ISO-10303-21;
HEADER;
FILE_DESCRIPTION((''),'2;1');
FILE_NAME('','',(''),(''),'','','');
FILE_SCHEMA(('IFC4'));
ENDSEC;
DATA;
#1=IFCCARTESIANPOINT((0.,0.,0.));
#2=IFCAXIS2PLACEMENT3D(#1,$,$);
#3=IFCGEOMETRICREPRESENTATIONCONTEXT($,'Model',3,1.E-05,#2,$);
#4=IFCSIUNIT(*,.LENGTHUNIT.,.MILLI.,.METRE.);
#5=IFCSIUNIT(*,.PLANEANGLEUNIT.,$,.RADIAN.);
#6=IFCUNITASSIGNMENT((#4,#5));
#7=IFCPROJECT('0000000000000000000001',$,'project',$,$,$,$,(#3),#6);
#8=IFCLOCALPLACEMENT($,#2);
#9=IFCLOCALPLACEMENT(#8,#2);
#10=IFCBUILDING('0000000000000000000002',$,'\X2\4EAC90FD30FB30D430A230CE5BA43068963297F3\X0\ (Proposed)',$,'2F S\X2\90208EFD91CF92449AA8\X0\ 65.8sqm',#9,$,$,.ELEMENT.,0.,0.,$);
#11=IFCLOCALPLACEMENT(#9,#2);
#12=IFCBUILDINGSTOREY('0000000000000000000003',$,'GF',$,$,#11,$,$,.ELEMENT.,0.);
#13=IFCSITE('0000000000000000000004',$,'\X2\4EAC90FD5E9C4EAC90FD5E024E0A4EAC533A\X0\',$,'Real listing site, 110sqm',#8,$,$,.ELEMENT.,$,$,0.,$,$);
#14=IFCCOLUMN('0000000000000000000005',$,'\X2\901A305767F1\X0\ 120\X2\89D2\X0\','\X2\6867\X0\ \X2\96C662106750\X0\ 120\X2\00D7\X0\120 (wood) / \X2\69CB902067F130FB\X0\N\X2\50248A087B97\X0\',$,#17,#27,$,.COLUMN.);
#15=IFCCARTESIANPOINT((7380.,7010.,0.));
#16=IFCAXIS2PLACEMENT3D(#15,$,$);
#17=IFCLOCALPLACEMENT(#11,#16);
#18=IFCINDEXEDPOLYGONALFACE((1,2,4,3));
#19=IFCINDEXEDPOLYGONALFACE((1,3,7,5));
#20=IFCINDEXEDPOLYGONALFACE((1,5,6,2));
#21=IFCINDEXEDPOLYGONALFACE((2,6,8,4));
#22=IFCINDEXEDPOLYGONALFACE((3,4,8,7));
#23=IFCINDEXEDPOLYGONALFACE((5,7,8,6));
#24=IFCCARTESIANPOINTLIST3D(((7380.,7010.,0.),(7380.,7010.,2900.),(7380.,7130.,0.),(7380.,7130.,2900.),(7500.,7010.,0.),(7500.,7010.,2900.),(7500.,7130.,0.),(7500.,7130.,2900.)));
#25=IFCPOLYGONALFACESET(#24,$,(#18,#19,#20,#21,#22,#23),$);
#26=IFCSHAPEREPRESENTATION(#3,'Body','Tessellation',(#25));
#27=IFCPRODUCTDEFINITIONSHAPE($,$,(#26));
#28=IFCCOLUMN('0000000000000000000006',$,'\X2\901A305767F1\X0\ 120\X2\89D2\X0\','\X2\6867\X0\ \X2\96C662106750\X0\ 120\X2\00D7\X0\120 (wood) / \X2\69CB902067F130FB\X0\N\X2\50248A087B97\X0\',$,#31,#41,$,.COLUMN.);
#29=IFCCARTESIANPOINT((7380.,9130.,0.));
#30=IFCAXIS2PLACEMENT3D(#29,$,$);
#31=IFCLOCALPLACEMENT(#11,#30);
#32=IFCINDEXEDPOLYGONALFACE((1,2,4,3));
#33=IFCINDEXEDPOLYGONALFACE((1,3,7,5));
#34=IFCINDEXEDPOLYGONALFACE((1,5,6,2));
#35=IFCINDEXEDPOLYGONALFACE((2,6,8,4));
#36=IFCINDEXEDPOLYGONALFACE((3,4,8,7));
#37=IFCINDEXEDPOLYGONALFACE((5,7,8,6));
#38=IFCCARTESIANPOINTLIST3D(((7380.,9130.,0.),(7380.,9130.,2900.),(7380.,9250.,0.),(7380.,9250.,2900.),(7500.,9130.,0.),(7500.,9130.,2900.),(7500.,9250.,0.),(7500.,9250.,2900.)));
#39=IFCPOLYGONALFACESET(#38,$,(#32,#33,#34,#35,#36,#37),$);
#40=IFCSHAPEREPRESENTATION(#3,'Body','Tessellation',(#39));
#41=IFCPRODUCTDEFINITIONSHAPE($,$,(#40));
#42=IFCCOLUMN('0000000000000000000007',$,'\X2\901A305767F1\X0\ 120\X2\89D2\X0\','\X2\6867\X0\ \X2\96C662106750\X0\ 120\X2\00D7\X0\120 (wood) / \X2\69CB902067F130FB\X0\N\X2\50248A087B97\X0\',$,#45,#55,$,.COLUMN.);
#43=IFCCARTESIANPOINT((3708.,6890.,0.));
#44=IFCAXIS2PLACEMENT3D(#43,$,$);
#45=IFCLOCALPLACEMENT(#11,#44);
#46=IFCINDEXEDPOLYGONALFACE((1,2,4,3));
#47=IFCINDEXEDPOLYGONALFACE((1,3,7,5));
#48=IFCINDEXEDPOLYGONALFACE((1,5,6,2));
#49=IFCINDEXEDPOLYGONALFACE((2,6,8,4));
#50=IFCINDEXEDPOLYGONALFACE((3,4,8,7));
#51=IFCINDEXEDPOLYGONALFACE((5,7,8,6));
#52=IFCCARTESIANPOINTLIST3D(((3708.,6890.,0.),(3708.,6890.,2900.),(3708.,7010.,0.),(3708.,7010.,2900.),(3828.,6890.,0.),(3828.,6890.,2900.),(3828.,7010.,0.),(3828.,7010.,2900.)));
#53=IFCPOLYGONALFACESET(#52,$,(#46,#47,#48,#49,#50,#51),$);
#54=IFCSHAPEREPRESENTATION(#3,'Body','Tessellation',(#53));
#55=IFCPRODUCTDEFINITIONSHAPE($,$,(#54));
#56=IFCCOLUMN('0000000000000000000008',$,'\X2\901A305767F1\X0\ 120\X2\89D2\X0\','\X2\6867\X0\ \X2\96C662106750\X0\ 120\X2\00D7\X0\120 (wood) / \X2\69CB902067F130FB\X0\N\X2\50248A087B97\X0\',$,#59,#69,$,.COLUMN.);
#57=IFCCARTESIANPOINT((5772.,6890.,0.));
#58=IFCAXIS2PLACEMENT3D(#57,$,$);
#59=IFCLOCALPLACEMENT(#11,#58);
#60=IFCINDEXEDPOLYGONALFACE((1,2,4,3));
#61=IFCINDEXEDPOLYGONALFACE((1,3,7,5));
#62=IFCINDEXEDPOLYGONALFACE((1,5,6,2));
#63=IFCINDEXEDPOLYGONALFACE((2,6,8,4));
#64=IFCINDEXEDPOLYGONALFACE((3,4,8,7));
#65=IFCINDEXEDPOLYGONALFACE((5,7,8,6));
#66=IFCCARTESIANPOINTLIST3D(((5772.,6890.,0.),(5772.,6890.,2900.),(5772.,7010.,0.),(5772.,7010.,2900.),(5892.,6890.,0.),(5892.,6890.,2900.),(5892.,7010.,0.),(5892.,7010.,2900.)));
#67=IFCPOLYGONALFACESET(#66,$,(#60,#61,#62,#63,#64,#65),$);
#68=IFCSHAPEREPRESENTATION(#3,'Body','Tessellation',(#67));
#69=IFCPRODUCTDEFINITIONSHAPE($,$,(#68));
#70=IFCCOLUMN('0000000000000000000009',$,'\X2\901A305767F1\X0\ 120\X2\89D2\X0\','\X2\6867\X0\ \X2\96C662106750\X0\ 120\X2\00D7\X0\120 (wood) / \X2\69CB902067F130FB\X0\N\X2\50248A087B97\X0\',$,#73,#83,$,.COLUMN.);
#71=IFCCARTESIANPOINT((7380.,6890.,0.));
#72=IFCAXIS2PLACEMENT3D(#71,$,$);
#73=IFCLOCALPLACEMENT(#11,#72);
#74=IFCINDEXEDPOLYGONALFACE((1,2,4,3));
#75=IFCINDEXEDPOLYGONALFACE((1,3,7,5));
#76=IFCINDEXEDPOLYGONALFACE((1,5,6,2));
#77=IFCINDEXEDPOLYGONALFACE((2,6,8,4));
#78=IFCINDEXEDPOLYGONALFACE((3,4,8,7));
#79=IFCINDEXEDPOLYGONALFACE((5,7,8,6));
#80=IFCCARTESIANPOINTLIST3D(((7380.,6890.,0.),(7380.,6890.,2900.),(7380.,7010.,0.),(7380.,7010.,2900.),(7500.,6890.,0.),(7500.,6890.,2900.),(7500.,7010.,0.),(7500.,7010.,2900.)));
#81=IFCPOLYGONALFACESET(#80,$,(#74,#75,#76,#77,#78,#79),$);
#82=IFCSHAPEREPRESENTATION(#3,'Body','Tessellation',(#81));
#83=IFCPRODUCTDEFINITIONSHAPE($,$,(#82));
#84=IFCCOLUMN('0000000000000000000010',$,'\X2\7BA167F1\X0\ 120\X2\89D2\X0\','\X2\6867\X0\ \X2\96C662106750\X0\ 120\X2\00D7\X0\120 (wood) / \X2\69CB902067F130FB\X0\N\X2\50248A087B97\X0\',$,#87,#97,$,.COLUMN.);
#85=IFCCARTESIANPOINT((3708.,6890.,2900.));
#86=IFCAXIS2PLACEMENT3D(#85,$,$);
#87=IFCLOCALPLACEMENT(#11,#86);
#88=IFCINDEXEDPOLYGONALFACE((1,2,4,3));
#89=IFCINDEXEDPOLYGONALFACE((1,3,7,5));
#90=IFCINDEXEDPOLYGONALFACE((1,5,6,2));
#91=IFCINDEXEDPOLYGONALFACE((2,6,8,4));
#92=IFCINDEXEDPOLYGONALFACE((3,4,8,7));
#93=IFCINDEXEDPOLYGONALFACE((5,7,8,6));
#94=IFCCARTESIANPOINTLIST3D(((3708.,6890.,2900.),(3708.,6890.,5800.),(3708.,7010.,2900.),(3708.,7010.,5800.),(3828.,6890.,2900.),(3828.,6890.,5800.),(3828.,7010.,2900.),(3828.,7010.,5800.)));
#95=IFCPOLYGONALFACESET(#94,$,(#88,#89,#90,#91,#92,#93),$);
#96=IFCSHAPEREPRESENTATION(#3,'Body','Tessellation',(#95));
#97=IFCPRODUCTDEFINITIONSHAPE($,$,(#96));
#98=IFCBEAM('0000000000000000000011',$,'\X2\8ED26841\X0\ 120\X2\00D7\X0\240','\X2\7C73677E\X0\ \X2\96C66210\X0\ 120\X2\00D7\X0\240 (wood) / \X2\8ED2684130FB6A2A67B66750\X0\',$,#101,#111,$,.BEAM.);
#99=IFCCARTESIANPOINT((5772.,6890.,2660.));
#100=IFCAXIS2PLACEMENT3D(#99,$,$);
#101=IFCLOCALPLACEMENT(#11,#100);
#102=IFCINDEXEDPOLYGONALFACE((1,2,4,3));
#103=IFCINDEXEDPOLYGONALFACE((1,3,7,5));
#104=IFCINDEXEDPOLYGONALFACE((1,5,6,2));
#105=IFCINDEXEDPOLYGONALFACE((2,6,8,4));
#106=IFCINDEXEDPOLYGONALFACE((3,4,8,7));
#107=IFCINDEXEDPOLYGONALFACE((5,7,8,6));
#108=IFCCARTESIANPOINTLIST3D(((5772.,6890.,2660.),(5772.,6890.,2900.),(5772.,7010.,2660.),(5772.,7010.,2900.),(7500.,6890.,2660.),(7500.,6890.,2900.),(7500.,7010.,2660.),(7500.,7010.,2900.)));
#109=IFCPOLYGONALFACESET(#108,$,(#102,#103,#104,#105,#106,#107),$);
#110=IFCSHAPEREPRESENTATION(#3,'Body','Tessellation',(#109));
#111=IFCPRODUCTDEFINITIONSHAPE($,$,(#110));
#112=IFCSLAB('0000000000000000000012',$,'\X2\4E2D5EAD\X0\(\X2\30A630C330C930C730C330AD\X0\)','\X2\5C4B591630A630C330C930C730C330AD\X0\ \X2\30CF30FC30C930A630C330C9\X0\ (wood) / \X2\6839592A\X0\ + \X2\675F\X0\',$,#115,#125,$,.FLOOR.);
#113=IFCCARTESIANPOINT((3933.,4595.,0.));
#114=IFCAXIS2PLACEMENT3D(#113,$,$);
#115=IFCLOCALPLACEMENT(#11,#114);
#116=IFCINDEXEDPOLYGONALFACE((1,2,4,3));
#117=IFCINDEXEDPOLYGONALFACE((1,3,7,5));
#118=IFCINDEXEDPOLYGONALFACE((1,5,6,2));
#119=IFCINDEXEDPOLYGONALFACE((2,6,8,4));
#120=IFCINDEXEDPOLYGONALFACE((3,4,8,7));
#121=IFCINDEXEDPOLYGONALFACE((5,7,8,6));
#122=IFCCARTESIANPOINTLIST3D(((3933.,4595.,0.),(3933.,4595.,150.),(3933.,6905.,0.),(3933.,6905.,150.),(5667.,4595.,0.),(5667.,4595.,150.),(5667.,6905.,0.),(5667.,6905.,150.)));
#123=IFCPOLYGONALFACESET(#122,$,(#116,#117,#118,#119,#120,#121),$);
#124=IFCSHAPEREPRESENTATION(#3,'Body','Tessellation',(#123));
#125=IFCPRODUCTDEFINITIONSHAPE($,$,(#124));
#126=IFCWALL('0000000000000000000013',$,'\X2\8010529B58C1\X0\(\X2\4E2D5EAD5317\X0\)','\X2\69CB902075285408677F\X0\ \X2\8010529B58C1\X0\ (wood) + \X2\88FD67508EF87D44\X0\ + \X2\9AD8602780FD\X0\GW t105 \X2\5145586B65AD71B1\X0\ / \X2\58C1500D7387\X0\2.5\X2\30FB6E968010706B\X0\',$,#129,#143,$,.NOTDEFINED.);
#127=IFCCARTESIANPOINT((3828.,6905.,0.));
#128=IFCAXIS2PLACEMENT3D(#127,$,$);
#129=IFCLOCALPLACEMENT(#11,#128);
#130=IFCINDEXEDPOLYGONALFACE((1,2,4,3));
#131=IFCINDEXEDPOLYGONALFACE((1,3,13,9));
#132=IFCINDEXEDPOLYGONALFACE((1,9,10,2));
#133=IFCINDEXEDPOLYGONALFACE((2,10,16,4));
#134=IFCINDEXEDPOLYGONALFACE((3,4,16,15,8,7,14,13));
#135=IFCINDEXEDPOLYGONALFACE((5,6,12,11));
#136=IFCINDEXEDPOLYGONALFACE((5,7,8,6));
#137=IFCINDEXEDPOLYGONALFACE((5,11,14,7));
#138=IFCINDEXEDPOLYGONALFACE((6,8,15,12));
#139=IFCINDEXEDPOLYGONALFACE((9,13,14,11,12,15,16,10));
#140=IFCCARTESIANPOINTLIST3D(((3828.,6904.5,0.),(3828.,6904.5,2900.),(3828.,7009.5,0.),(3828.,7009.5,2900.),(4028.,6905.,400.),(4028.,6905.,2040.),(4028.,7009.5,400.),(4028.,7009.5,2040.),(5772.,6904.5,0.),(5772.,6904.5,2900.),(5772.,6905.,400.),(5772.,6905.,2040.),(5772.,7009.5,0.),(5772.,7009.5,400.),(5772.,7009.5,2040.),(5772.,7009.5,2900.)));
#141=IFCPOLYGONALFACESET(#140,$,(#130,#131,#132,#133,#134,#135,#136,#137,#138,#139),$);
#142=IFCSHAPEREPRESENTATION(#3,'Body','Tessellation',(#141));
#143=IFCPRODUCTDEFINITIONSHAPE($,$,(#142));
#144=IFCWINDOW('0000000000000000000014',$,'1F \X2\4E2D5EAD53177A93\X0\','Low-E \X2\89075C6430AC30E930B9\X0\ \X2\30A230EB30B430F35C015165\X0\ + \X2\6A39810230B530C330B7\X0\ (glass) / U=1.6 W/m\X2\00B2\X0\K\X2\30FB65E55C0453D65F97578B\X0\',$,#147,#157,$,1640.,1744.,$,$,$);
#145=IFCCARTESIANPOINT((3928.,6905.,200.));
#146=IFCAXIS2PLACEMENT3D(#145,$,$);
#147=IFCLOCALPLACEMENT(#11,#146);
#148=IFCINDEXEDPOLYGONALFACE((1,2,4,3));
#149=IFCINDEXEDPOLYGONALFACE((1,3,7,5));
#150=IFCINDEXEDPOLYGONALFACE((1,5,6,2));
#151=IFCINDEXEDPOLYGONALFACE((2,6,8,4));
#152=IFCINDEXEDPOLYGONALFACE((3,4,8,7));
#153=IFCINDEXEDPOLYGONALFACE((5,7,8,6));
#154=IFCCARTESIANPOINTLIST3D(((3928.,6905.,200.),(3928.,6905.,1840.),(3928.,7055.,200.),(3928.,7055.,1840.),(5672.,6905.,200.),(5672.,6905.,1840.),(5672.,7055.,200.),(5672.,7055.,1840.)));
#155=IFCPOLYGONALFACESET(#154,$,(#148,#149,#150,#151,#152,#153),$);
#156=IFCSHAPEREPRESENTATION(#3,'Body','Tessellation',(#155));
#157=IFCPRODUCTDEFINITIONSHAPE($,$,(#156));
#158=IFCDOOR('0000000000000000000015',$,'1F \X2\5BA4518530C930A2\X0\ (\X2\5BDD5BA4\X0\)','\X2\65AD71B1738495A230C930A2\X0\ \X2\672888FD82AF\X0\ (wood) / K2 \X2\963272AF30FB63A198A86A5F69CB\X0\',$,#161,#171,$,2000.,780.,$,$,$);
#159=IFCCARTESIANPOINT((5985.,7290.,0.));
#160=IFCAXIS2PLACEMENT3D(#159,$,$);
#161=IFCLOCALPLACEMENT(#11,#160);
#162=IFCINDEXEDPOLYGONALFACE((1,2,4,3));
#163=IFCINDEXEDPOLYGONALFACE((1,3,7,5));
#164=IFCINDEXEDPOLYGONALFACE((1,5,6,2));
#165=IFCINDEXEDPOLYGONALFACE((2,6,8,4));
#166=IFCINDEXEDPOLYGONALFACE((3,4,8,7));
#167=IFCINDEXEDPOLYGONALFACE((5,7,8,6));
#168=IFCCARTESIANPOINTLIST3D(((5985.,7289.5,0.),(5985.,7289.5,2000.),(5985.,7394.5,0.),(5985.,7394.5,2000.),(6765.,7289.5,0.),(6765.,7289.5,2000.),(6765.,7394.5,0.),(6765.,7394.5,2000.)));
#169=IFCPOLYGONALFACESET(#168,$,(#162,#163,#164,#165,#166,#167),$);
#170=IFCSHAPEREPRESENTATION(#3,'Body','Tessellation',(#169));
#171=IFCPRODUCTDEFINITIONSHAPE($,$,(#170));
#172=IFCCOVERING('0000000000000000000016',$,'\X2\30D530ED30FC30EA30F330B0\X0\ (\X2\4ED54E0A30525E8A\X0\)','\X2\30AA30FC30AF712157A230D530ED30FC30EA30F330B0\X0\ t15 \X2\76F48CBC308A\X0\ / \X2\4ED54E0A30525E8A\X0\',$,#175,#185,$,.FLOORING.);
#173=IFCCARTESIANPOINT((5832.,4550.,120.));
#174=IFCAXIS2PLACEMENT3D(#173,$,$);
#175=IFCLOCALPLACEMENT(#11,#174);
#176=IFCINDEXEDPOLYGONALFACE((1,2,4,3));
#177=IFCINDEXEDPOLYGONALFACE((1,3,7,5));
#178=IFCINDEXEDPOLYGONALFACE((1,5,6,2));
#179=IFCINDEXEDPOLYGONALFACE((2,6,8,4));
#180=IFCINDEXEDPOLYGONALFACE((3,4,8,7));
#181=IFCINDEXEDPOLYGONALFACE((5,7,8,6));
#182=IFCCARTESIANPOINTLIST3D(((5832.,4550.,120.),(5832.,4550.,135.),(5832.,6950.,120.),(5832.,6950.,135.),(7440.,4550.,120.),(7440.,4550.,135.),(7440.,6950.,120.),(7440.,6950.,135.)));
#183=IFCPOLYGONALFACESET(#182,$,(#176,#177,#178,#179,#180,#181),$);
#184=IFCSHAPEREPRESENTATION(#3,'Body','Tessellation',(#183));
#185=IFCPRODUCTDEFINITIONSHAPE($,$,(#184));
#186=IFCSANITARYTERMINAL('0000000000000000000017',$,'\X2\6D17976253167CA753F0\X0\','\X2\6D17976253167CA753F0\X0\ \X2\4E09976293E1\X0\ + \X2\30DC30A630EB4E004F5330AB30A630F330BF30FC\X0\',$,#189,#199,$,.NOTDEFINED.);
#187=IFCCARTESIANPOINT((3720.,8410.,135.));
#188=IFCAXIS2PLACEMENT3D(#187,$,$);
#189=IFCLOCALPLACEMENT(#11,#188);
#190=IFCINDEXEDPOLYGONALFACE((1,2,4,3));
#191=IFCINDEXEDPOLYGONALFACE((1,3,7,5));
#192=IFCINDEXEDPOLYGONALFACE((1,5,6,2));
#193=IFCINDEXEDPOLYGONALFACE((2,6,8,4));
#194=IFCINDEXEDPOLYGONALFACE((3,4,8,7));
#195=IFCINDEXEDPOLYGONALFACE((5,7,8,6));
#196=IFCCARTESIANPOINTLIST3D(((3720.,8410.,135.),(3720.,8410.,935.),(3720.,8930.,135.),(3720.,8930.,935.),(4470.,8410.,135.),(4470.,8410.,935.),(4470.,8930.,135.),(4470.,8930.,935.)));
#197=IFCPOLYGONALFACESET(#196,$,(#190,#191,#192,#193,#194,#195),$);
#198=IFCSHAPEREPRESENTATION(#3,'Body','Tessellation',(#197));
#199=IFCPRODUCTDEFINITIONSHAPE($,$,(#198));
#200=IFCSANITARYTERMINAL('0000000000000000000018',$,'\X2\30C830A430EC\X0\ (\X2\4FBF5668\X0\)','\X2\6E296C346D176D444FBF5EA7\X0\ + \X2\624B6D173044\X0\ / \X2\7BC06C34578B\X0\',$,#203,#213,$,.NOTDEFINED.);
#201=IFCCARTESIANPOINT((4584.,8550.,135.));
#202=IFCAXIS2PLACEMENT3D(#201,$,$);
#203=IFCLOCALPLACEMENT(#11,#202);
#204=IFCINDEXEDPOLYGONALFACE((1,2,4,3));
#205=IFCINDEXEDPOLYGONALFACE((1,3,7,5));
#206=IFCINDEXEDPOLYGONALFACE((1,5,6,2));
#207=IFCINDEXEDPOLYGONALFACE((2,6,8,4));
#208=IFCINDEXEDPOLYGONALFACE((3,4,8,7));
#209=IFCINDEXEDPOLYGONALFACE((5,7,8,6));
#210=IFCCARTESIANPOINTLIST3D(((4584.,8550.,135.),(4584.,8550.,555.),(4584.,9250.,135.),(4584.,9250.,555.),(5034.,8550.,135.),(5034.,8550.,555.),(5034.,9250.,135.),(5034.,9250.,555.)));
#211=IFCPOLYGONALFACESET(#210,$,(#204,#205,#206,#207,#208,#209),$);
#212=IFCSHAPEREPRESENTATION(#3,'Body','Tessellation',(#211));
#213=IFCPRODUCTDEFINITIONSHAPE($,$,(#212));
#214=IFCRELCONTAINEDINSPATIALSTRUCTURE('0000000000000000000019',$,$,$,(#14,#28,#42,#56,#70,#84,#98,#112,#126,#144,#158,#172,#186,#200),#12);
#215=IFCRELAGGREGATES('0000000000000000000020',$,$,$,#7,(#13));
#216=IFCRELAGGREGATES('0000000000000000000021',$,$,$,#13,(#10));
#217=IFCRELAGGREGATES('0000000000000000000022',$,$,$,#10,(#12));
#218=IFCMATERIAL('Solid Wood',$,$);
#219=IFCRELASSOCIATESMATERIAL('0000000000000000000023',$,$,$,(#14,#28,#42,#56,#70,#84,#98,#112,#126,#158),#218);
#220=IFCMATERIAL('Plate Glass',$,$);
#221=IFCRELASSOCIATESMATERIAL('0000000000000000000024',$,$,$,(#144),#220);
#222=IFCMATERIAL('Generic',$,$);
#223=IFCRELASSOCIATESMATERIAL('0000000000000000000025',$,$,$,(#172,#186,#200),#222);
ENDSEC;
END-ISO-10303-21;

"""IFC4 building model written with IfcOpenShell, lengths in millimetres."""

from ifc_helpers import new_model, si_unit, frame, frame_2d, origin, place, context, project, spatial, rectangle, extrude, material, element, fill, save


model = new_model("IFC4")

# Units and contexts
model_context = context("Model", 3, precision=1e-05, world=origin())
ifc_project = project(units=[si_unit("LENGTHUNIT", "METRE", prefix="MILLI"), si_unit("PLANEANGLEUNIT", "RADIAN")], contexts=[model_context])

# Site, building, storey
site_placement = place(None, origin())
site = spatial("IfcSite", under=ifc_project, at=site_placement, Name="京都府京都市上京区", ObjectType="Real listing site, 110sqm", CompositionType="ELEMENT", RefElevation=0.0)
building_placement = place(site_placement, origin())
building = spatial("IfcBuilding", under=site, at=building_placement, Name="京都・ピアノ室と防音 (Proposed)", ObjectType="2F S造軽量鉄骨 65.8sqm", CompositionType="ELEMENT", ElevationOfRefHeight=0.0, ElevationOfTerrain=0.0)
storey_placement = place(building_placement, origin())
storey = spatial("IfcBuildingStorey", under=building, at=storey_placement, Name="GF", CompositionType="ELEMENT", Elevation=0.0)

# Columns
ifc_material_1 = material(Name="Solid Wood")
column_1_placement = place(storey_placement, frame((7380.0, 7010.0, 0.0)))
element("IfcColumn", 1, at=column_1_placement, inside=storey, material=ifc_material_1, Name="通し柱 120角", Description="桧 集成材 120×120 (wood) / 構造柱・N値計算", PredefinedType="COLUMN", context=model_context, shape_type="SweptSolid", body=[
    extrude(rectangle(XDim=120.0, YDim=120.0, at=frame_2d((60.0, 60.0))), frame((7380.0, 7010.0, 0.0)), (0.0, 0.0, 1.0), 2900.0),
])
column_2_placement = place(storey_placement, frame((7380.0, 9130.0, 0.0)))
element("IfcColumn", 2, at=column_2_placement, inside=storey, material=ifc_material_1, Name="通し柱 120角", Description="桧 集成材 120×120 (wood) / 構造柱・N値計算", PredefinedType="COLUMN", context=model_context, shape_type="SweptSolid", body=[
    extrude(rectangle(XDim=120.0, YDim=120.0, at=frame_2d((60.0, 60.0))), frame((7380.0, 9130.0, 0.0)), (0.0, 0.0, 1.0), 2900.0),
])
column_3_placement = place(storey_placement, frame((3708.0, 6890.0, 0.0)))
element("IfcColumn", 3, at=column_3_placement, inside=storey, material=ifc_material_1, Name="通し柱 120角", Description="桧 集成材 120×120 (wood) / 構造柱・N値計算", PredefinedType="COLUMN", context=model_context, shape_type="SweptSolid", body=[
    extrude(rectangle(XDim=120.0, YDim=120.0, at=frame_2d((60.0, 60.0))), frame((3708.0, 6890.0, 0.0)), (0.0, 0.0, 1.0), 2900.0),
])
column_4_placement = place(storey_placement, frame((5772.0, 6890.0, 0.0)))
element("IfcColumn", 4, at=column_4_placement, inside=storey, material=ifc_material_1, Name="通し柱 120角", Description="桧 集成材 120×120 (wood) / 構造柱・N値計算", PredefinedType="COLUMN", context=model_context, shape_type="SweptSolid", body=[
    extrude(rectangle(XDim=120.0, YDim=120.0, at=frame_2d((60.0, 60.0))), frame((5772.0, 6890.0, 0.0)), (0.0, 0.0, 1.0), 2900.0),
])
column_5_placement = place(storey_placement, frame((7380.0, 6890.0, 0.0)))
element("IfcColumn", 5, at=column_5_placement, inside=storey, material=ifc_material_1, Name="通し柱 120角", Description="桧 集成材 120×120 (wood) / 構造柱・N値計算", PredefinedType="COLUMN", context=model_context, shape_type="SweptSolid", body=[
    extrude(rectangle(XDim=120.0, YDim=120.0, at=frame_2d((60.0, 60.0))), frame((7380.0, 6890.0, 0.0)), (0.0, 0.0, 1.0), 2900.0),
])
column_6_placement = place(storey_placement, frame((3708.0, 6890.0, 2900.0)))
element("IfcColumn", 6, at=column_6_placement, inside=storey, material=ifc_material_1, Name="管柱 120角", Description="桧 集成材 120×120 (wood) / 構造柱・N値計算", PredefinedType="COLUMN", context=model_context, shape_type="SweptSolid", body=[
    extrude(rectangle(XDim=120.0, YDim=120.0, at=frame_2d((60.0, 60.0))), frame((3708.0, 6890.0, 2900.0)), (0.0, 0.0, 1.0), 2900.0),
])

# Beam
beam_1_placement = place(storey_placement, frame((5772.0, 6890.0, 2660.0)))
element("IfcBeam", 7, at=beam_1_placement, inside=storey, material=ifc_material_1, Name="軒桁 120×240", Description="米松 集成 120×240 (wood) / 軒桁・横架材", PredefinedType="BEAM", context=model_context, shape_type="SweptSolid", body=[
    extrude(rectangle(XDim=1728.0, YDim=120.0, at=frame_2d((864.0, 60.0))), frame((5772.0, 6890.0, 2660.0)), (0.0, 0.0, 1.0), 240.0),
])

# Slab
slab_placement = place(storey_placement, frame((3933.0, 4595.0, 0.0)))
element("IfcSlab", 8, at=slab_placement, inside=storey, material=ifc_material_1, Name="中庭(ウッドデッキ)", Description="屋外ウッドデッキ ハードウッド (wood) / 根太 + 束", PredefinedType="FLOOR", context=model_context, shape_type="SweptSolid", body=[
    extrude(rectangle(XDim=1734.0, YDim=2310.0, at=frame_2d((867.0, 1155.0))), frame((3933.0, 4595.0, 0.0)), (0.0, 0.0, 1.0), 150.0),
])

# Wall, opening, window
wall_1_placement = place(storey_placement, frame((3828.0, 6905.0, 0.0)))
wall_1 = element("IfcWall", 9, at=wall_1_placement, inside=storey, material=ifc_material_1, Name="耐力壁(中庭北)", Description="構造用合板 耐力壁 (wood) + 製材軸組 + 高性能GW t105 充填断熱 / 壁倍率2.5・準耐火", PredefinedType="NOTDEFINED", context=model_context, shape_type="SweptSolid", body=[
    extrude(rectangle(XDim=1944.0, YDim=105.0, at=frame_2d((972.0, 52.0))), frame((3828.0, 6905.0, 0.0)), (0.0, 0.0, 1.0), 2900.0),
])
opening_placement = place(storey_placement, frame((3928.0, 6905.0, 200.0)))
opening = element("IfcOpeningElement", 10, at=opening_placement, cuts=wall_1, PredefinedType="NOTDEFINED", context=model_context, shape_type="SweptSolid", body=[
    extrude(rectangle(XDim=1744.0, YDim=150.0, at=frame_2d((872.0, 75.0))), frame((3928.0, 6905.0, 200.0)), (0.0, 0.0, 1.0), 1640.0),
])
ifc_material_2 = material(Name="Plate Glass")
window_placement = place(storey_placement, frame((3928.0, 6905.0, 200.0)))
window = element("IfcWindow", 11, at=window_placement, inside=storey, material=ifc_material_2, Name="1F 中庭北窓", Description="Low-E 複層ガラス アルゴン封入 + 樹脂サッシ (glass) / U=1.6 W/m²K・日射取得型", OverallHeight=1640.0, OverallWidth=1744.0, context=model_context, shape_type="SweptSolid", body=[
    extrude(rectangle(XDim=1744.0, YDim=150.0, at=frame_2d((872.0, 75.0))), frame((3928.0, 6905.0, 200.0)), (0.0, 0.0, 1.0), 1640.0),
])
fill(opening, window)

# Door
door_placement = place(storey_placement, frame((5985.0, 7290.0, 0.0)))
element("IfcDoor", 12, at=door_placement, inside=storey, material=ifc_material_1, Name="1F 室内ドア (寝室)", Description="断熱玄関ドア 木製芯 (wood) / K2 防犯・採風機構", OverallHeight=2000.0, OverallWidth=780.0, context=model_context, shape_type="SweptSolid", body=[
    extrude(rectangle(XDim=780.0, YDim=105.0, at=frame_2d((390.0, 52.0))), frame((5985.0, 7290.0, 0.0)), (0.0, 0.0, 1.0), 2000.0),
])

# Covering
ifc_material_3 = material(Name="Generic")
covering_placement = place(storey_placement, frame((5832.0, 4550.0, 120.0)))
element("IfcCovering", 13, at=covering_placement, inside=storey, material=ifc_material_3, Name="フローリング (仕上げ床)", Description="オーク無垢フローリング t15 直貼り / 仕上げ床", PredefinedType="FLOORING", context=model_context, shape_type="SweptSolid", body=[
    extrude(rectangle(XDim=1608.0, YDim=2400.0, at=frame_2d((804.0, 1200.0))), frame((5832.0, 4550.0, 120.0)), (0.0, 0.0, 1.0), 15.0),
])

# Sanitary terminals
sanitary_terminal_1_placement = place(storey_placement, frame((3720.0, 8410.0, 135.0)))
element("IfcSanitaryTerminal", 14, at=sanitary_terminal_1_placement, inside=storey, material=ifc_material_3, Name="洗面化粧台", Description="洗面化粧台 三面鏡 + ボウル一体カウンター", PredefinedType="NOTDEFINED", context=model_context, shape_type="SweptSolid", body=[
    extrude(rectangle(XDim=750.0, YDim=520.0, at=frame_2d((375.0, 260.0))), frame((3720.0, 8410.0, 135.0)), (0.0, 0.0, 1.0), 800.0),
])
sanitary_terminal_2_placement = place(storey_placement, frame((4584.0, 8550.0, 135.0)))
element("IfcSanitaryTerminal", 15, at=sanitary_terminal_2_placement, inside=storey, material=ifc_material_3, Name="トイレ (便器)", Description="温水洗浄便座 + 手洗い / 節水型", PredefinedType="NOTDEFINED", context=model_context, shape_type="SweptSolid", body=[
    extrude(rectangle(XDim=450.0, YDim=700.0, at=frame_2d((225.0, 350.0))), frame((4584.0, 8550.0, 135.0)), (0.0, 0.0, 1.0), 420.0),
])

save(model, "model.ifc")
